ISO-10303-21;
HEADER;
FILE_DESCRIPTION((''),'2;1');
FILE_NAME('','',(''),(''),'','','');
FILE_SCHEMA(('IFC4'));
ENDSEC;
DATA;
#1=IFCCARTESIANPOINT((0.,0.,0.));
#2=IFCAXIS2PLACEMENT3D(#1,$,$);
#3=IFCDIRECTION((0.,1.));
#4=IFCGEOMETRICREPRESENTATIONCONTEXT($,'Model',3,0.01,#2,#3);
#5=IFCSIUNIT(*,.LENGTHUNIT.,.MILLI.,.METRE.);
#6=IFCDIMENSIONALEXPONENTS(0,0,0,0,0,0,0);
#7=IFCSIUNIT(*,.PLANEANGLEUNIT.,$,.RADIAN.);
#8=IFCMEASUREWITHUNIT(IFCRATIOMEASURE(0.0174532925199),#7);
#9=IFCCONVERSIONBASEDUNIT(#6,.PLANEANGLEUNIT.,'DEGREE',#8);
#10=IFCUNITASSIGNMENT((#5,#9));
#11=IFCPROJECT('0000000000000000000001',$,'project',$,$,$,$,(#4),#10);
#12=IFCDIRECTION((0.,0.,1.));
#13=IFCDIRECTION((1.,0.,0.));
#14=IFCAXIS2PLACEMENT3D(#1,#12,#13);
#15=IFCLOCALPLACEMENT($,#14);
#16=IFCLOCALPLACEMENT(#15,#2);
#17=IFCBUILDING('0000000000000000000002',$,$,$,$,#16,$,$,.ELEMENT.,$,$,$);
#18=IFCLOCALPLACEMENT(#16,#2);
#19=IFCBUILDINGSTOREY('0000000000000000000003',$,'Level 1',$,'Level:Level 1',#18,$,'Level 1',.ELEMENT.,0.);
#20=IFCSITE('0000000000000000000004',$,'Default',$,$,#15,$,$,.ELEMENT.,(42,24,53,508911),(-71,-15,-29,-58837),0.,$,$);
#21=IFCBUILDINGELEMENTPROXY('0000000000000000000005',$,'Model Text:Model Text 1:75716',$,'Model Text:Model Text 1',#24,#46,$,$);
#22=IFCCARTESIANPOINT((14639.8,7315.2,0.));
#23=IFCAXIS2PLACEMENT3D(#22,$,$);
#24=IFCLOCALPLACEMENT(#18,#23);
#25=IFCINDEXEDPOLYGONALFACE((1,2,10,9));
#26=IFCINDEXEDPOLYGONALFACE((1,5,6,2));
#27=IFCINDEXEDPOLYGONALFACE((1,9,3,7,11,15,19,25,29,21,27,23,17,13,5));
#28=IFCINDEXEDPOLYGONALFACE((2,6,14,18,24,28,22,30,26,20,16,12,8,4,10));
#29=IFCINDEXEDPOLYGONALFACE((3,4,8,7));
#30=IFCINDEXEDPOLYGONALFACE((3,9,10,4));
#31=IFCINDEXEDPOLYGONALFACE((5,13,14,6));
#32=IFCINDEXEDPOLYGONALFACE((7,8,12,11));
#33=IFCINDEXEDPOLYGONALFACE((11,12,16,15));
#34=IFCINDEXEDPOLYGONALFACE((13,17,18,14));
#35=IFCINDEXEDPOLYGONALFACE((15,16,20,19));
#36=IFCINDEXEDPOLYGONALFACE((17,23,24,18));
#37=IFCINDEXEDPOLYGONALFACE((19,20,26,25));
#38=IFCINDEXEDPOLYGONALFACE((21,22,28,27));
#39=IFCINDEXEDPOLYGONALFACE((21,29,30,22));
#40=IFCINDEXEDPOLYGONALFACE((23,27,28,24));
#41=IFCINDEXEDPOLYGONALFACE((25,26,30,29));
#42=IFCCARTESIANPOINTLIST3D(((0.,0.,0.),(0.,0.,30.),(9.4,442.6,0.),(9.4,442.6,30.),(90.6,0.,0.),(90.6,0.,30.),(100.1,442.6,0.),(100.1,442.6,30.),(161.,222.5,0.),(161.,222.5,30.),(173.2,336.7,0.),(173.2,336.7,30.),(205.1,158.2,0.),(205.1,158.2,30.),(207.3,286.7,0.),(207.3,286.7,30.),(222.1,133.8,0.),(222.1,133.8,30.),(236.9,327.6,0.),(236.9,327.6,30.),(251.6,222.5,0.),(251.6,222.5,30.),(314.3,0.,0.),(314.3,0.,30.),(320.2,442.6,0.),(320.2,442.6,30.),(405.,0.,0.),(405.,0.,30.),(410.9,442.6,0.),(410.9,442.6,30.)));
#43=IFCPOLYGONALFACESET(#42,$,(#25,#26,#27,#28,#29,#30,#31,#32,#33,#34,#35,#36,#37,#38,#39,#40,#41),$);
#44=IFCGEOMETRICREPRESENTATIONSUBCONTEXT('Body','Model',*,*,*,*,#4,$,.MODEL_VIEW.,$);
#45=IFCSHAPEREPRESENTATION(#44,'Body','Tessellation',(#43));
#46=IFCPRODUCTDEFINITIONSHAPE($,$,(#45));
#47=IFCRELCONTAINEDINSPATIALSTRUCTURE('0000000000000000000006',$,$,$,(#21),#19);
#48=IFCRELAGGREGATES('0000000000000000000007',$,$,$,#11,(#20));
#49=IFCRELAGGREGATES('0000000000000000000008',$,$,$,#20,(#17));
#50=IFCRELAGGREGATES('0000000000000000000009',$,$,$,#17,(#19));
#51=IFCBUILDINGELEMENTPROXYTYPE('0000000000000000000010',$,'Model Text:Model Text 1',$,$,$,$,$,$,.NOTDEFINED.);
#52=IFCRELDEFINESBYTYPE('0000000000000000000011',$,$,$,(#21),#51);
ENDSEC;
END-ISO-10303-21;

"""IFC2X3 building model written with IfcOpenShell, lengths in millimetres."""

from ifc_helpers import new_model, entity, si_unit, converted_unit, direction, frame, origin, origin_with_axes, place, context, subcontext, project, spatial, polyline, outline, extrude, type_object, element, save


model = new_model("IFC2X3")

# Units and contexts
model_context = context("Model", 3, precision=0.01, world=origin(), true_north=direction((0.0, 1.0)))
body_context = subcontext(model_context, "Body", "Model", "MODEL_VIEW")
ifc_project = project(units=[si_unit("LENGTHUNIT", "METRE", prefix="MILLI"), converted_unit("PLANEANGLEUNIT", "DEGREE", entity("IfcRatioMeasure", 0.0174532925199), si_unit("PLANEANGLEUNIT", "RADIAN"), dimensions=[0, 0, 0, 0, 0, 0, 0])], contexts=[model_context])

# Site, building, storey
site_placement = place(None, origin_with_axes())
site = spatial("IfcSite", under=ifc_project, at=site_placement, Name="Default", CompositionType="ELEMENT", RefLatitude=(42, 24, 53, 508911), RefLongitude=(-71, -15, -29, -58837), RefElevation=0.0)
building_placement = place(site_placement, origin())
building = spatial("IfcBuilding", under=site, at=building_placement, CompositionType="ELEMENT")
storey_placement = place(building_placement, origin())
storey = spatial("IfcBuildingStorey", under=building, at=storey_placement, Name="Level 1", ObjectType="Level:Level 1", LongName="Level 1", CompositionType="ELEMENT", Elevation=0.0)

# Building element proxy
building_element_proxy_type_1 = type_object("IfcBuildingElementProxyType", Name="Model Text:Model Text 1", PredefinedType="NOTDEFINED")
proxy_1_placement = place(storey_placement, frame((14639.8, 7315.2, 0.0)))
element("IfcBuildingElementProxy", 1, at=proxy_1_placement, inside=storey, type_object=building_element_proxy_type_1, Name="Model Text:Model Text 1:75716", ObjectType="Model Text:Model Text 1", context=body_context, shape_type="SweptSolid", body=[
    extrude(outline(polyline([(-207.2, -230.6), (-116.5, -230.6), (-2.1, -72.4), (14.9, -96.8), (107.1, -230.6), (197.8, -230.6), (44.4, -8.1), (203.7, 212.1), (113.0, 212.1), (29.7, 97.0), (0.2, 56.1), (-34.0, 106.1), (-107.1, 212.1), (-197.8, 212.1), (-46.2, -8.1), (-207.2, -230.6)])), frame((207.2, 230.6, 0.0)), (0.0, 0.0, 1.0), 30.0),
])

save(model, "model.ifc")
